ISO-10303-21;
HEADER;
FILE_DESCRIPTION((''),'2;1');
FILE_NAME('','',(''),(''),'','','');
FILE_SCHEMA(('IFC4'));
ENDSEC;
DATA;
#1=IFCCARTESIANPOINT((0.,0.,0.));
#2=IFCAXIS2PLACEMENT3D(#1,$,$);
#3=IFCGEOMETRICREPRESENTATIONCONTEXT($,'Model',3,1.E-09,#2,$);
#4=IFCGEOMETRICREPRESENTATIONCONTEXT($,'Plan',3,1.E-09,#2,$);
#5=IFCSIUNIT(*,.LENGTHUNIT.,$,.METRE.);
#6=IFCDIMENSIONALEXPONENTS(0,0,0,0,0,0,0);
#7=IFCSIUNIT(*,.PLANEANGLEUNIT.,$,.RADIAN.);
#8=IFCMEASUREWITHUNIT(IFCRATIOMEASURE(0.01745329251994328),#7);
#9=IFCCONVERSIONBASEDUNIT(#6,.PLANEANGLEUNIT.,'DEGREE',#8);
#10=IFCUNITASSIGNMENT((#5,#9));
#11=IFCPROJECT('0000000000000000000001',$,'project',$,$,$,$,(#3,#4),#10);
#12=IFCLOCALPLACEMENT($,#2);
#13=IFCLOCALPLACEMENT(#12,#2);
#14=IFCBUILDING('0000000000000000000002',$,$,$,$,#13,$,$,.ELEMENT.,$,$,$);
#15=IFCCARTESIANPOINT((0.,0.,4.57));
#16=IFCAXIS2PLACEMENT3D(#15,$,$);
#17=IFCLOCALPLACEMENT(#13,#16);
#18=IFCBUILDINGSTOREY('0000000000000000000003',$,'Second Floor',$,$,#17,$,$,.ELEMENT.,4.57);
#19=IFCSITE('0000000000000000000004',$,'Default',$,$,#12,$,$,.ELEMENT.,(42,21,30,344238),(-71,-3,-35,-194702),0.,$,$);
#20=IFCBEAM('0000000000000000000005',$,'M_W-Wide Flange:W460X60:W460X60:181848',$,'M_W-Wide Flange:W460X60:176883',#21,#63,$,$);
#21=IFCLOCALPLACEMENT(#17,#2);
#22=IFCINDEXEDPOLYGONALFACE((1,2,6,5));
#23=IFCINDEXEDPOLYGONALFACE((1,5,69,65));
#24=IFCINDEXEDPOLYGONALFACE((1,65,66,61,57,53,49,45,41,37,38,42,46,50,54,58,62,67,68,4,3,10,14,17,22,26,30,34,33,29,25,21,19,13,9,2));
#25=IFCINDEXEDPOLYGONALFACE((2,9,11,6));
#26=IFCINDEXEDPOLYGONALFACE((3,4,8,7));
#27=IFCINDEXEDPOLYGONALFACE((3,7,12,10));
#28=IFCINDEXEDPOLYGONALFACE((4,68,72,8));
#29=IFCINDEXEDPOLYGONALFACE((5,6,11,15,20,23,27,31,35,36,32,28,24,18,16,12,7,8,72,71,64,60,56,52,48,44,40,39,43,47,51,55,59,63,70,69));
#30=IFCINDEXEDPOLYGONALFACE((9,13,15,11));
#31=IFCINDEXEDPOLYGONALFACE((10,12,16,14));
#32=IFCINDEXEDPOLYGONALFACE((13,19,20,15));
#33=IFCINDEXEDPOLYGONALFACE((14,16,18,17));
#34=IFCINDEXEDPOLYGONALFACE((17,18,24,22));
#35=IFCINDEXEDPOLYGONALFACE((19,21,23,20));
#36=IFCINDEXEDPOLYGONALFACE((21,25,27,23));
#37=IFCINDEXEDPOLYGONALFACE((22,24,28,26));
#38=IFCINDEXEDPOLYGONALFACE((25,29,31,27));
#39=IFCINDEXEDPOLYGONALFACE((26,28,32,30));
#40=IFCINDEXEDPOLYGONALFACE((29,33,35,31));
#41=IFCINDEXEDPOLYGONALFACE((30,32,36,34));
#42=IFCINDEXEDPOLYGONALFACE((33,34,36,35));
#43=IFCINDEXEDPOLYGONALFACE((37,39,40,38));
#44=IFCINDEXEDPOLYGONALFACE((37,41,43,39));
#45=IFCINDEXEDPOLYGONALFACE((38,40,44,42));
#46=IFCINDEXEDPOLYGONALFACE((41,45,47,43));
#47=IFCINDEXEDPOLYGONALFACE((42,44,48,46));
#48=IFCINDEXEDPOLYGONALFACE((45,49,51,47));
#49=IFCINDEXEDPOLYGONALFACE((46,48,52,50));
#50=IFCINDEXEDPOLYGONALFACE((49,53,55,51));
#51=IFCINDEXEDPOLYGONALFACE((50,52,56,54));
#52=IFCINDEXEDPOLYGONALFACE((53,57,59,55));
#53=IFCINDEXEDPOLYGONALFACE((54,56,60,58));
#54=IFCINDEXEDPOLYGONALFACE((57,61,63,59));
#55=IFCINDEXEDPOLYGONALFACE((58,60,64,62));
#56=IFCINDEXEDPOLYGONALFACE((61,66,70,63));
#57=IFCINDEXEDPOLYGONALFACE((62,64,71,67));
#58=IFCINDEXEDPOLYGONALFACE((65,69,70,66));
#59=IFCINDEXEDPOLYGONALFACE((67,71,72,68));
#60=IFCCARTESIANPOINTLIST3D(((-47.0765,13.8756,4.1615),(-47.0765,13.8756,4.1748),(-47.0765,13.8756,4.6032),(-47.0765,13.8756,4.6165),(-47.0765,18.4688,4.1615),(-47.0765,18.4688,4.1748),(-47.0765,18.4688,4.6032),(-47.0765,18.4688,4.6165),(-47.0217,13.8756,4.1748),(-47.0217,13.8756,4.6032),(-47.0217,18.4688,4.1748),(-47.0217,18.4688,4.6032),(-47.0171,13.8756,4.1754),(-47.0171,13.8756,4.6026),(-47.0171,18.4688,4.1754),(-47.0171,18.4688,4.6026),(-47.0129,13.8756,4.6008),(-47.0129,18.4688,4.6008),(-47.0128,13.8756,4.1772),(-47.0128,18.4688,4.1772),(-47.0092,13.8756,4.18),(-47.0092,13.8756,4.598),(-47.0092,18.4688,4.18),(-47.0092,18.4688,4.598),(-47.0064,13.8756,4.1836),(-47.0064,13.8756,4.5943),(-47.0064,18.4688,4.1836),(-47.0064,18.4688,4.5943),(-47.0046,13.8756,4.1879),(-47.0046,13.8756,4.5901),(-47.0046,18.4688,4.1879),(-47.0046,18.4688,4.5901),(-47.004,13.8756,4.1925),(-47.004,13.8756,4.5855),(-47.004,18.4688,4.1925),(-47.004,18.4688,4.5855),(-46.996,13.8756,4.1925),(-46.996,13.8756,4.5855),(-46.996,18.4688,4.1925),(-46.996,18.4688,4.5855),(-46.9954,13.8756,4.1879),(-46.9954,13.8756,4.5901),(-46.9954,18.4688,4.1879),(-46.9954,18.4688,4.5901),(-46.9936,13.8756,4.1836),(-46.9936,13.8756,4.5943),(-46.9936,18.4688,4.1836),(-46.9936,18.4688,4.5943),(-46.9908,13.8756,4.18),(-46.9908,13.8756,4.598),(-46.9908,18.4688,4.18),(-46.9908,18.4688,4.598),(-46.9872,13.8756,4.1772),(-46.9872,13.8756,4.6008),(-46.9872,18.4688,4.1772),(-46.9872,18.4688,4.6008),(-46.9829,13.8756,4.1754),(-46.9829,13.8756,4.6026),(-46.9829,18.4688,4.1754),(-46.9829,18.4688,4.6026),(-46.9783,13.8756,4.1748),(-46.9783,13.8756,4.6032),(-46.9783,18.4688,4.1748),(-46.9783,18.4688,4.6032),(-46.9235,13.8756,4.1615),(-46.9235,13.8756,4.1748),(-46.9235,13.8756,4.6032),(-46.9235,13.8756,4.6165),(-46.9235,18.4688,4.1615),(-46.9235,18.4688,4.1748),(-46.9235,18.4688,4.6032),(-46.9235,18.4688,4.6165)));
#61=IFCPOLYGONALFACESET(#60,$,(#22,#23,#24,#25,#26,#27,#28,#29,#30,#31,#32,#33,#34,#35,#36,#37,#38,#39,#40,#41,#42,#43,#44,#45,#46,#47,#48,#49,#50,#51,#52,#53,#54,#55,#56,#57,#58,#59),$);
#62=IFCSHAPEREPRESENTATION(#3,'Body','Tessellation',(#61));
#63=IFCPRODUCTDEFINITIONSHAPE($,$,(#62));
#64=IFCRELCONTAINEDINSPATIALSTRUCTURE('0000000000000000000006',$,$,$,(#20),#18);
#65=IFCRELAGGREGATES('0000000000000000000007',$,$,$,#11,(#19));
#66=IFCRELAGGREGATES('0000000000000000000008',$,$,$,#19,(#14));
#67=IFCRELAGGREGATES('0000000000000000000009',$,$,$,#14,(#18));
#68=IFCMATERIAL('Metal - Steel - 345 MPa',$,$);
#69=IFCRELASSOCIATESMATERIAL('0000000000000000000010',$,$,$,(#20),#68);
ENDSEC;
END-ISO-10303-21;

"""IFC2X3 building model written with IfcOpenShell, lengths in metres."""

from ifc_helpers import new_model, entity, si_unit, converted_unit, frame, frame_2d, origin, place, context, project, spatial, polyline, circle_curve, parameter, trimmed, segment, composite_curve, outline, extrude, material, element, save


model = new_model("IFC2X3")

# Units and contexts
model_context = context("Model", 3, precision=1e-09, world=origin())
plan_context = context("Plan", 3, precision=1e-09, world=origin())
ifc_project = project(units=[si_unit("LENGTHUNIT", "METRE"), converted_unit("PLANEANGLEUNIT", "DEGREE", entity("IfcRatioMeasure", 0.01745329251994328), si_unit("PLANEANGLEUNIT", "RADIAN"), dimensions=[0, 0, 0, 0, 0, 0, 0])], contexts=[model_context, plan_context])

# Site, building, storey
site_placement = place(None, origin())
site = spatial("IfcSite", under=ifc_project, at=site_placement, Name="Default", CompositionType="ELEMENT", RefLatitude=(42, 21, 30, 344238), RefLongitude=(-71, -3, -35, -194702), RefElevation=0.0)
building_placement = place(site_placement, origin())
building = spatial("IfcBuilding", under=site, at=building_placement, CompositionType="ELEMENT")
storey_placement = place(building_placement, frame((0.0, 0.0, 4.57)))
storey = spatial("IfcBuildingStorey", under=building, at=storey_placement, Name="Second Floor", CompositionType="ELEMENT", Elevation=4.57)

# Shared definitions
ifc_material_1 = material(Name="Metal - Steel - 345 MPa")

# Beam
beam_1_placement = place(storey_placement, frame((-47.0, 18.6061, 4.6165), z_axis=(0.0, 0.0, 1.0), x_axis=(-1.0, 0.0, 0.0)))
element("IfcBeam", 1, at=beam_1_placement, inside=storey, material=ifc_material_1, Name="M_W-Wide Flange:W460X60:W460X60:181848", ObjectType="M_W-Wide Flange:W460X60:176883", context=model_context, shape_type="SweptSolid", body=[
    extrude(outline(composite_curve([segment(polyline([(0.2142, -0.0765), (0.2275, -0.0765)]), True, "CONTINUOUS"), segment(polyline([(0.2275, -0.0765), (0.2275, 0.0765)]), True, "CONTINUOUS"), segment(polyline([(0.2275, 0.0765), (0.2142, 0.0765)]), True, "CONTINUOUS"), segment(polyline([(0.2142, 0.0765), (0.2142, 0.0217)]), True, "CONTINUOUS"), segment(trimmed(circle_curve(frame_2d((0.1965, 0.0217), x_axis=(1.0, 0.0)), 0.0177), [parameter(270.0)], [parameter(360.0)], True, "PARAMETER"), False, "CONTINUOUS"), segment(polyline([(0.1965, 0.004), (-0.1965, 0.004)]), True, "CONTINUOUS"), segment(trimmed(circle_curve(frame_2d((-0.1965, 0.0217), x_axis=(0.0, -1.0)), 0.0177), [parameter(270.0)], [parameter(360.0)], True, "PARAMETER"), False, "CONTINUOUS"), segment(polyline([(-0.2142, 0.0217), (-0.2142, 0.0765)]), True, "CONTINUOUS"), segment(polyline([(-0.2142, 0.0765), (-0.2275, 0.0765)]), True, "CONTINUOUS"), segment(polyline([(-0.2275, 0.0765), (-0.2275, -0.0765)]), True, "CONTINUOUS"), segment(polyline([(-0.2275, -0.0765), (-0.2142, -0.0765)]), True, "CONTINUOUS"), segment(polyline([(-0.2142, -0.0765), (-0.2142, -0.0217)]), True, "CONTINUOUS"), segment(trimmed(circle_curve(frame_2d((-0.1965, -0.0217), x_axis=(-1.0, 0.0)), 0.0177), [parameter(270.0)], [parameter(360.0)], True, "PARAMETER"), False, "CONTINUOUS"), segment(polyline([(-0.1965, -0.004), (0.1965, -0.004)]), True, "CONTINUOUS"), segment(trimmed(circle_curve(frame_2d((0.1965, -0.0217), x_axis=(0.0, 1.0)), 0.0177), [parameter(270.0)], [parameter(0.0)], True, "PARAMETER"), False, "CONTINUOUS"), segment(polyline([(0.2142, -0.0217), (0.2142, -0.0765)]), True, "CONTINUOUS")], self_intersect=False)), frame((0.0, 4.7305, -0.2275), z_axis=(0.0, -1.0, 0.0), x_axis=(0.0, 0.0, -1.0)), (0.0, 0.0, 1.0), 4.5932),
])

save(model, "model.ifc")
